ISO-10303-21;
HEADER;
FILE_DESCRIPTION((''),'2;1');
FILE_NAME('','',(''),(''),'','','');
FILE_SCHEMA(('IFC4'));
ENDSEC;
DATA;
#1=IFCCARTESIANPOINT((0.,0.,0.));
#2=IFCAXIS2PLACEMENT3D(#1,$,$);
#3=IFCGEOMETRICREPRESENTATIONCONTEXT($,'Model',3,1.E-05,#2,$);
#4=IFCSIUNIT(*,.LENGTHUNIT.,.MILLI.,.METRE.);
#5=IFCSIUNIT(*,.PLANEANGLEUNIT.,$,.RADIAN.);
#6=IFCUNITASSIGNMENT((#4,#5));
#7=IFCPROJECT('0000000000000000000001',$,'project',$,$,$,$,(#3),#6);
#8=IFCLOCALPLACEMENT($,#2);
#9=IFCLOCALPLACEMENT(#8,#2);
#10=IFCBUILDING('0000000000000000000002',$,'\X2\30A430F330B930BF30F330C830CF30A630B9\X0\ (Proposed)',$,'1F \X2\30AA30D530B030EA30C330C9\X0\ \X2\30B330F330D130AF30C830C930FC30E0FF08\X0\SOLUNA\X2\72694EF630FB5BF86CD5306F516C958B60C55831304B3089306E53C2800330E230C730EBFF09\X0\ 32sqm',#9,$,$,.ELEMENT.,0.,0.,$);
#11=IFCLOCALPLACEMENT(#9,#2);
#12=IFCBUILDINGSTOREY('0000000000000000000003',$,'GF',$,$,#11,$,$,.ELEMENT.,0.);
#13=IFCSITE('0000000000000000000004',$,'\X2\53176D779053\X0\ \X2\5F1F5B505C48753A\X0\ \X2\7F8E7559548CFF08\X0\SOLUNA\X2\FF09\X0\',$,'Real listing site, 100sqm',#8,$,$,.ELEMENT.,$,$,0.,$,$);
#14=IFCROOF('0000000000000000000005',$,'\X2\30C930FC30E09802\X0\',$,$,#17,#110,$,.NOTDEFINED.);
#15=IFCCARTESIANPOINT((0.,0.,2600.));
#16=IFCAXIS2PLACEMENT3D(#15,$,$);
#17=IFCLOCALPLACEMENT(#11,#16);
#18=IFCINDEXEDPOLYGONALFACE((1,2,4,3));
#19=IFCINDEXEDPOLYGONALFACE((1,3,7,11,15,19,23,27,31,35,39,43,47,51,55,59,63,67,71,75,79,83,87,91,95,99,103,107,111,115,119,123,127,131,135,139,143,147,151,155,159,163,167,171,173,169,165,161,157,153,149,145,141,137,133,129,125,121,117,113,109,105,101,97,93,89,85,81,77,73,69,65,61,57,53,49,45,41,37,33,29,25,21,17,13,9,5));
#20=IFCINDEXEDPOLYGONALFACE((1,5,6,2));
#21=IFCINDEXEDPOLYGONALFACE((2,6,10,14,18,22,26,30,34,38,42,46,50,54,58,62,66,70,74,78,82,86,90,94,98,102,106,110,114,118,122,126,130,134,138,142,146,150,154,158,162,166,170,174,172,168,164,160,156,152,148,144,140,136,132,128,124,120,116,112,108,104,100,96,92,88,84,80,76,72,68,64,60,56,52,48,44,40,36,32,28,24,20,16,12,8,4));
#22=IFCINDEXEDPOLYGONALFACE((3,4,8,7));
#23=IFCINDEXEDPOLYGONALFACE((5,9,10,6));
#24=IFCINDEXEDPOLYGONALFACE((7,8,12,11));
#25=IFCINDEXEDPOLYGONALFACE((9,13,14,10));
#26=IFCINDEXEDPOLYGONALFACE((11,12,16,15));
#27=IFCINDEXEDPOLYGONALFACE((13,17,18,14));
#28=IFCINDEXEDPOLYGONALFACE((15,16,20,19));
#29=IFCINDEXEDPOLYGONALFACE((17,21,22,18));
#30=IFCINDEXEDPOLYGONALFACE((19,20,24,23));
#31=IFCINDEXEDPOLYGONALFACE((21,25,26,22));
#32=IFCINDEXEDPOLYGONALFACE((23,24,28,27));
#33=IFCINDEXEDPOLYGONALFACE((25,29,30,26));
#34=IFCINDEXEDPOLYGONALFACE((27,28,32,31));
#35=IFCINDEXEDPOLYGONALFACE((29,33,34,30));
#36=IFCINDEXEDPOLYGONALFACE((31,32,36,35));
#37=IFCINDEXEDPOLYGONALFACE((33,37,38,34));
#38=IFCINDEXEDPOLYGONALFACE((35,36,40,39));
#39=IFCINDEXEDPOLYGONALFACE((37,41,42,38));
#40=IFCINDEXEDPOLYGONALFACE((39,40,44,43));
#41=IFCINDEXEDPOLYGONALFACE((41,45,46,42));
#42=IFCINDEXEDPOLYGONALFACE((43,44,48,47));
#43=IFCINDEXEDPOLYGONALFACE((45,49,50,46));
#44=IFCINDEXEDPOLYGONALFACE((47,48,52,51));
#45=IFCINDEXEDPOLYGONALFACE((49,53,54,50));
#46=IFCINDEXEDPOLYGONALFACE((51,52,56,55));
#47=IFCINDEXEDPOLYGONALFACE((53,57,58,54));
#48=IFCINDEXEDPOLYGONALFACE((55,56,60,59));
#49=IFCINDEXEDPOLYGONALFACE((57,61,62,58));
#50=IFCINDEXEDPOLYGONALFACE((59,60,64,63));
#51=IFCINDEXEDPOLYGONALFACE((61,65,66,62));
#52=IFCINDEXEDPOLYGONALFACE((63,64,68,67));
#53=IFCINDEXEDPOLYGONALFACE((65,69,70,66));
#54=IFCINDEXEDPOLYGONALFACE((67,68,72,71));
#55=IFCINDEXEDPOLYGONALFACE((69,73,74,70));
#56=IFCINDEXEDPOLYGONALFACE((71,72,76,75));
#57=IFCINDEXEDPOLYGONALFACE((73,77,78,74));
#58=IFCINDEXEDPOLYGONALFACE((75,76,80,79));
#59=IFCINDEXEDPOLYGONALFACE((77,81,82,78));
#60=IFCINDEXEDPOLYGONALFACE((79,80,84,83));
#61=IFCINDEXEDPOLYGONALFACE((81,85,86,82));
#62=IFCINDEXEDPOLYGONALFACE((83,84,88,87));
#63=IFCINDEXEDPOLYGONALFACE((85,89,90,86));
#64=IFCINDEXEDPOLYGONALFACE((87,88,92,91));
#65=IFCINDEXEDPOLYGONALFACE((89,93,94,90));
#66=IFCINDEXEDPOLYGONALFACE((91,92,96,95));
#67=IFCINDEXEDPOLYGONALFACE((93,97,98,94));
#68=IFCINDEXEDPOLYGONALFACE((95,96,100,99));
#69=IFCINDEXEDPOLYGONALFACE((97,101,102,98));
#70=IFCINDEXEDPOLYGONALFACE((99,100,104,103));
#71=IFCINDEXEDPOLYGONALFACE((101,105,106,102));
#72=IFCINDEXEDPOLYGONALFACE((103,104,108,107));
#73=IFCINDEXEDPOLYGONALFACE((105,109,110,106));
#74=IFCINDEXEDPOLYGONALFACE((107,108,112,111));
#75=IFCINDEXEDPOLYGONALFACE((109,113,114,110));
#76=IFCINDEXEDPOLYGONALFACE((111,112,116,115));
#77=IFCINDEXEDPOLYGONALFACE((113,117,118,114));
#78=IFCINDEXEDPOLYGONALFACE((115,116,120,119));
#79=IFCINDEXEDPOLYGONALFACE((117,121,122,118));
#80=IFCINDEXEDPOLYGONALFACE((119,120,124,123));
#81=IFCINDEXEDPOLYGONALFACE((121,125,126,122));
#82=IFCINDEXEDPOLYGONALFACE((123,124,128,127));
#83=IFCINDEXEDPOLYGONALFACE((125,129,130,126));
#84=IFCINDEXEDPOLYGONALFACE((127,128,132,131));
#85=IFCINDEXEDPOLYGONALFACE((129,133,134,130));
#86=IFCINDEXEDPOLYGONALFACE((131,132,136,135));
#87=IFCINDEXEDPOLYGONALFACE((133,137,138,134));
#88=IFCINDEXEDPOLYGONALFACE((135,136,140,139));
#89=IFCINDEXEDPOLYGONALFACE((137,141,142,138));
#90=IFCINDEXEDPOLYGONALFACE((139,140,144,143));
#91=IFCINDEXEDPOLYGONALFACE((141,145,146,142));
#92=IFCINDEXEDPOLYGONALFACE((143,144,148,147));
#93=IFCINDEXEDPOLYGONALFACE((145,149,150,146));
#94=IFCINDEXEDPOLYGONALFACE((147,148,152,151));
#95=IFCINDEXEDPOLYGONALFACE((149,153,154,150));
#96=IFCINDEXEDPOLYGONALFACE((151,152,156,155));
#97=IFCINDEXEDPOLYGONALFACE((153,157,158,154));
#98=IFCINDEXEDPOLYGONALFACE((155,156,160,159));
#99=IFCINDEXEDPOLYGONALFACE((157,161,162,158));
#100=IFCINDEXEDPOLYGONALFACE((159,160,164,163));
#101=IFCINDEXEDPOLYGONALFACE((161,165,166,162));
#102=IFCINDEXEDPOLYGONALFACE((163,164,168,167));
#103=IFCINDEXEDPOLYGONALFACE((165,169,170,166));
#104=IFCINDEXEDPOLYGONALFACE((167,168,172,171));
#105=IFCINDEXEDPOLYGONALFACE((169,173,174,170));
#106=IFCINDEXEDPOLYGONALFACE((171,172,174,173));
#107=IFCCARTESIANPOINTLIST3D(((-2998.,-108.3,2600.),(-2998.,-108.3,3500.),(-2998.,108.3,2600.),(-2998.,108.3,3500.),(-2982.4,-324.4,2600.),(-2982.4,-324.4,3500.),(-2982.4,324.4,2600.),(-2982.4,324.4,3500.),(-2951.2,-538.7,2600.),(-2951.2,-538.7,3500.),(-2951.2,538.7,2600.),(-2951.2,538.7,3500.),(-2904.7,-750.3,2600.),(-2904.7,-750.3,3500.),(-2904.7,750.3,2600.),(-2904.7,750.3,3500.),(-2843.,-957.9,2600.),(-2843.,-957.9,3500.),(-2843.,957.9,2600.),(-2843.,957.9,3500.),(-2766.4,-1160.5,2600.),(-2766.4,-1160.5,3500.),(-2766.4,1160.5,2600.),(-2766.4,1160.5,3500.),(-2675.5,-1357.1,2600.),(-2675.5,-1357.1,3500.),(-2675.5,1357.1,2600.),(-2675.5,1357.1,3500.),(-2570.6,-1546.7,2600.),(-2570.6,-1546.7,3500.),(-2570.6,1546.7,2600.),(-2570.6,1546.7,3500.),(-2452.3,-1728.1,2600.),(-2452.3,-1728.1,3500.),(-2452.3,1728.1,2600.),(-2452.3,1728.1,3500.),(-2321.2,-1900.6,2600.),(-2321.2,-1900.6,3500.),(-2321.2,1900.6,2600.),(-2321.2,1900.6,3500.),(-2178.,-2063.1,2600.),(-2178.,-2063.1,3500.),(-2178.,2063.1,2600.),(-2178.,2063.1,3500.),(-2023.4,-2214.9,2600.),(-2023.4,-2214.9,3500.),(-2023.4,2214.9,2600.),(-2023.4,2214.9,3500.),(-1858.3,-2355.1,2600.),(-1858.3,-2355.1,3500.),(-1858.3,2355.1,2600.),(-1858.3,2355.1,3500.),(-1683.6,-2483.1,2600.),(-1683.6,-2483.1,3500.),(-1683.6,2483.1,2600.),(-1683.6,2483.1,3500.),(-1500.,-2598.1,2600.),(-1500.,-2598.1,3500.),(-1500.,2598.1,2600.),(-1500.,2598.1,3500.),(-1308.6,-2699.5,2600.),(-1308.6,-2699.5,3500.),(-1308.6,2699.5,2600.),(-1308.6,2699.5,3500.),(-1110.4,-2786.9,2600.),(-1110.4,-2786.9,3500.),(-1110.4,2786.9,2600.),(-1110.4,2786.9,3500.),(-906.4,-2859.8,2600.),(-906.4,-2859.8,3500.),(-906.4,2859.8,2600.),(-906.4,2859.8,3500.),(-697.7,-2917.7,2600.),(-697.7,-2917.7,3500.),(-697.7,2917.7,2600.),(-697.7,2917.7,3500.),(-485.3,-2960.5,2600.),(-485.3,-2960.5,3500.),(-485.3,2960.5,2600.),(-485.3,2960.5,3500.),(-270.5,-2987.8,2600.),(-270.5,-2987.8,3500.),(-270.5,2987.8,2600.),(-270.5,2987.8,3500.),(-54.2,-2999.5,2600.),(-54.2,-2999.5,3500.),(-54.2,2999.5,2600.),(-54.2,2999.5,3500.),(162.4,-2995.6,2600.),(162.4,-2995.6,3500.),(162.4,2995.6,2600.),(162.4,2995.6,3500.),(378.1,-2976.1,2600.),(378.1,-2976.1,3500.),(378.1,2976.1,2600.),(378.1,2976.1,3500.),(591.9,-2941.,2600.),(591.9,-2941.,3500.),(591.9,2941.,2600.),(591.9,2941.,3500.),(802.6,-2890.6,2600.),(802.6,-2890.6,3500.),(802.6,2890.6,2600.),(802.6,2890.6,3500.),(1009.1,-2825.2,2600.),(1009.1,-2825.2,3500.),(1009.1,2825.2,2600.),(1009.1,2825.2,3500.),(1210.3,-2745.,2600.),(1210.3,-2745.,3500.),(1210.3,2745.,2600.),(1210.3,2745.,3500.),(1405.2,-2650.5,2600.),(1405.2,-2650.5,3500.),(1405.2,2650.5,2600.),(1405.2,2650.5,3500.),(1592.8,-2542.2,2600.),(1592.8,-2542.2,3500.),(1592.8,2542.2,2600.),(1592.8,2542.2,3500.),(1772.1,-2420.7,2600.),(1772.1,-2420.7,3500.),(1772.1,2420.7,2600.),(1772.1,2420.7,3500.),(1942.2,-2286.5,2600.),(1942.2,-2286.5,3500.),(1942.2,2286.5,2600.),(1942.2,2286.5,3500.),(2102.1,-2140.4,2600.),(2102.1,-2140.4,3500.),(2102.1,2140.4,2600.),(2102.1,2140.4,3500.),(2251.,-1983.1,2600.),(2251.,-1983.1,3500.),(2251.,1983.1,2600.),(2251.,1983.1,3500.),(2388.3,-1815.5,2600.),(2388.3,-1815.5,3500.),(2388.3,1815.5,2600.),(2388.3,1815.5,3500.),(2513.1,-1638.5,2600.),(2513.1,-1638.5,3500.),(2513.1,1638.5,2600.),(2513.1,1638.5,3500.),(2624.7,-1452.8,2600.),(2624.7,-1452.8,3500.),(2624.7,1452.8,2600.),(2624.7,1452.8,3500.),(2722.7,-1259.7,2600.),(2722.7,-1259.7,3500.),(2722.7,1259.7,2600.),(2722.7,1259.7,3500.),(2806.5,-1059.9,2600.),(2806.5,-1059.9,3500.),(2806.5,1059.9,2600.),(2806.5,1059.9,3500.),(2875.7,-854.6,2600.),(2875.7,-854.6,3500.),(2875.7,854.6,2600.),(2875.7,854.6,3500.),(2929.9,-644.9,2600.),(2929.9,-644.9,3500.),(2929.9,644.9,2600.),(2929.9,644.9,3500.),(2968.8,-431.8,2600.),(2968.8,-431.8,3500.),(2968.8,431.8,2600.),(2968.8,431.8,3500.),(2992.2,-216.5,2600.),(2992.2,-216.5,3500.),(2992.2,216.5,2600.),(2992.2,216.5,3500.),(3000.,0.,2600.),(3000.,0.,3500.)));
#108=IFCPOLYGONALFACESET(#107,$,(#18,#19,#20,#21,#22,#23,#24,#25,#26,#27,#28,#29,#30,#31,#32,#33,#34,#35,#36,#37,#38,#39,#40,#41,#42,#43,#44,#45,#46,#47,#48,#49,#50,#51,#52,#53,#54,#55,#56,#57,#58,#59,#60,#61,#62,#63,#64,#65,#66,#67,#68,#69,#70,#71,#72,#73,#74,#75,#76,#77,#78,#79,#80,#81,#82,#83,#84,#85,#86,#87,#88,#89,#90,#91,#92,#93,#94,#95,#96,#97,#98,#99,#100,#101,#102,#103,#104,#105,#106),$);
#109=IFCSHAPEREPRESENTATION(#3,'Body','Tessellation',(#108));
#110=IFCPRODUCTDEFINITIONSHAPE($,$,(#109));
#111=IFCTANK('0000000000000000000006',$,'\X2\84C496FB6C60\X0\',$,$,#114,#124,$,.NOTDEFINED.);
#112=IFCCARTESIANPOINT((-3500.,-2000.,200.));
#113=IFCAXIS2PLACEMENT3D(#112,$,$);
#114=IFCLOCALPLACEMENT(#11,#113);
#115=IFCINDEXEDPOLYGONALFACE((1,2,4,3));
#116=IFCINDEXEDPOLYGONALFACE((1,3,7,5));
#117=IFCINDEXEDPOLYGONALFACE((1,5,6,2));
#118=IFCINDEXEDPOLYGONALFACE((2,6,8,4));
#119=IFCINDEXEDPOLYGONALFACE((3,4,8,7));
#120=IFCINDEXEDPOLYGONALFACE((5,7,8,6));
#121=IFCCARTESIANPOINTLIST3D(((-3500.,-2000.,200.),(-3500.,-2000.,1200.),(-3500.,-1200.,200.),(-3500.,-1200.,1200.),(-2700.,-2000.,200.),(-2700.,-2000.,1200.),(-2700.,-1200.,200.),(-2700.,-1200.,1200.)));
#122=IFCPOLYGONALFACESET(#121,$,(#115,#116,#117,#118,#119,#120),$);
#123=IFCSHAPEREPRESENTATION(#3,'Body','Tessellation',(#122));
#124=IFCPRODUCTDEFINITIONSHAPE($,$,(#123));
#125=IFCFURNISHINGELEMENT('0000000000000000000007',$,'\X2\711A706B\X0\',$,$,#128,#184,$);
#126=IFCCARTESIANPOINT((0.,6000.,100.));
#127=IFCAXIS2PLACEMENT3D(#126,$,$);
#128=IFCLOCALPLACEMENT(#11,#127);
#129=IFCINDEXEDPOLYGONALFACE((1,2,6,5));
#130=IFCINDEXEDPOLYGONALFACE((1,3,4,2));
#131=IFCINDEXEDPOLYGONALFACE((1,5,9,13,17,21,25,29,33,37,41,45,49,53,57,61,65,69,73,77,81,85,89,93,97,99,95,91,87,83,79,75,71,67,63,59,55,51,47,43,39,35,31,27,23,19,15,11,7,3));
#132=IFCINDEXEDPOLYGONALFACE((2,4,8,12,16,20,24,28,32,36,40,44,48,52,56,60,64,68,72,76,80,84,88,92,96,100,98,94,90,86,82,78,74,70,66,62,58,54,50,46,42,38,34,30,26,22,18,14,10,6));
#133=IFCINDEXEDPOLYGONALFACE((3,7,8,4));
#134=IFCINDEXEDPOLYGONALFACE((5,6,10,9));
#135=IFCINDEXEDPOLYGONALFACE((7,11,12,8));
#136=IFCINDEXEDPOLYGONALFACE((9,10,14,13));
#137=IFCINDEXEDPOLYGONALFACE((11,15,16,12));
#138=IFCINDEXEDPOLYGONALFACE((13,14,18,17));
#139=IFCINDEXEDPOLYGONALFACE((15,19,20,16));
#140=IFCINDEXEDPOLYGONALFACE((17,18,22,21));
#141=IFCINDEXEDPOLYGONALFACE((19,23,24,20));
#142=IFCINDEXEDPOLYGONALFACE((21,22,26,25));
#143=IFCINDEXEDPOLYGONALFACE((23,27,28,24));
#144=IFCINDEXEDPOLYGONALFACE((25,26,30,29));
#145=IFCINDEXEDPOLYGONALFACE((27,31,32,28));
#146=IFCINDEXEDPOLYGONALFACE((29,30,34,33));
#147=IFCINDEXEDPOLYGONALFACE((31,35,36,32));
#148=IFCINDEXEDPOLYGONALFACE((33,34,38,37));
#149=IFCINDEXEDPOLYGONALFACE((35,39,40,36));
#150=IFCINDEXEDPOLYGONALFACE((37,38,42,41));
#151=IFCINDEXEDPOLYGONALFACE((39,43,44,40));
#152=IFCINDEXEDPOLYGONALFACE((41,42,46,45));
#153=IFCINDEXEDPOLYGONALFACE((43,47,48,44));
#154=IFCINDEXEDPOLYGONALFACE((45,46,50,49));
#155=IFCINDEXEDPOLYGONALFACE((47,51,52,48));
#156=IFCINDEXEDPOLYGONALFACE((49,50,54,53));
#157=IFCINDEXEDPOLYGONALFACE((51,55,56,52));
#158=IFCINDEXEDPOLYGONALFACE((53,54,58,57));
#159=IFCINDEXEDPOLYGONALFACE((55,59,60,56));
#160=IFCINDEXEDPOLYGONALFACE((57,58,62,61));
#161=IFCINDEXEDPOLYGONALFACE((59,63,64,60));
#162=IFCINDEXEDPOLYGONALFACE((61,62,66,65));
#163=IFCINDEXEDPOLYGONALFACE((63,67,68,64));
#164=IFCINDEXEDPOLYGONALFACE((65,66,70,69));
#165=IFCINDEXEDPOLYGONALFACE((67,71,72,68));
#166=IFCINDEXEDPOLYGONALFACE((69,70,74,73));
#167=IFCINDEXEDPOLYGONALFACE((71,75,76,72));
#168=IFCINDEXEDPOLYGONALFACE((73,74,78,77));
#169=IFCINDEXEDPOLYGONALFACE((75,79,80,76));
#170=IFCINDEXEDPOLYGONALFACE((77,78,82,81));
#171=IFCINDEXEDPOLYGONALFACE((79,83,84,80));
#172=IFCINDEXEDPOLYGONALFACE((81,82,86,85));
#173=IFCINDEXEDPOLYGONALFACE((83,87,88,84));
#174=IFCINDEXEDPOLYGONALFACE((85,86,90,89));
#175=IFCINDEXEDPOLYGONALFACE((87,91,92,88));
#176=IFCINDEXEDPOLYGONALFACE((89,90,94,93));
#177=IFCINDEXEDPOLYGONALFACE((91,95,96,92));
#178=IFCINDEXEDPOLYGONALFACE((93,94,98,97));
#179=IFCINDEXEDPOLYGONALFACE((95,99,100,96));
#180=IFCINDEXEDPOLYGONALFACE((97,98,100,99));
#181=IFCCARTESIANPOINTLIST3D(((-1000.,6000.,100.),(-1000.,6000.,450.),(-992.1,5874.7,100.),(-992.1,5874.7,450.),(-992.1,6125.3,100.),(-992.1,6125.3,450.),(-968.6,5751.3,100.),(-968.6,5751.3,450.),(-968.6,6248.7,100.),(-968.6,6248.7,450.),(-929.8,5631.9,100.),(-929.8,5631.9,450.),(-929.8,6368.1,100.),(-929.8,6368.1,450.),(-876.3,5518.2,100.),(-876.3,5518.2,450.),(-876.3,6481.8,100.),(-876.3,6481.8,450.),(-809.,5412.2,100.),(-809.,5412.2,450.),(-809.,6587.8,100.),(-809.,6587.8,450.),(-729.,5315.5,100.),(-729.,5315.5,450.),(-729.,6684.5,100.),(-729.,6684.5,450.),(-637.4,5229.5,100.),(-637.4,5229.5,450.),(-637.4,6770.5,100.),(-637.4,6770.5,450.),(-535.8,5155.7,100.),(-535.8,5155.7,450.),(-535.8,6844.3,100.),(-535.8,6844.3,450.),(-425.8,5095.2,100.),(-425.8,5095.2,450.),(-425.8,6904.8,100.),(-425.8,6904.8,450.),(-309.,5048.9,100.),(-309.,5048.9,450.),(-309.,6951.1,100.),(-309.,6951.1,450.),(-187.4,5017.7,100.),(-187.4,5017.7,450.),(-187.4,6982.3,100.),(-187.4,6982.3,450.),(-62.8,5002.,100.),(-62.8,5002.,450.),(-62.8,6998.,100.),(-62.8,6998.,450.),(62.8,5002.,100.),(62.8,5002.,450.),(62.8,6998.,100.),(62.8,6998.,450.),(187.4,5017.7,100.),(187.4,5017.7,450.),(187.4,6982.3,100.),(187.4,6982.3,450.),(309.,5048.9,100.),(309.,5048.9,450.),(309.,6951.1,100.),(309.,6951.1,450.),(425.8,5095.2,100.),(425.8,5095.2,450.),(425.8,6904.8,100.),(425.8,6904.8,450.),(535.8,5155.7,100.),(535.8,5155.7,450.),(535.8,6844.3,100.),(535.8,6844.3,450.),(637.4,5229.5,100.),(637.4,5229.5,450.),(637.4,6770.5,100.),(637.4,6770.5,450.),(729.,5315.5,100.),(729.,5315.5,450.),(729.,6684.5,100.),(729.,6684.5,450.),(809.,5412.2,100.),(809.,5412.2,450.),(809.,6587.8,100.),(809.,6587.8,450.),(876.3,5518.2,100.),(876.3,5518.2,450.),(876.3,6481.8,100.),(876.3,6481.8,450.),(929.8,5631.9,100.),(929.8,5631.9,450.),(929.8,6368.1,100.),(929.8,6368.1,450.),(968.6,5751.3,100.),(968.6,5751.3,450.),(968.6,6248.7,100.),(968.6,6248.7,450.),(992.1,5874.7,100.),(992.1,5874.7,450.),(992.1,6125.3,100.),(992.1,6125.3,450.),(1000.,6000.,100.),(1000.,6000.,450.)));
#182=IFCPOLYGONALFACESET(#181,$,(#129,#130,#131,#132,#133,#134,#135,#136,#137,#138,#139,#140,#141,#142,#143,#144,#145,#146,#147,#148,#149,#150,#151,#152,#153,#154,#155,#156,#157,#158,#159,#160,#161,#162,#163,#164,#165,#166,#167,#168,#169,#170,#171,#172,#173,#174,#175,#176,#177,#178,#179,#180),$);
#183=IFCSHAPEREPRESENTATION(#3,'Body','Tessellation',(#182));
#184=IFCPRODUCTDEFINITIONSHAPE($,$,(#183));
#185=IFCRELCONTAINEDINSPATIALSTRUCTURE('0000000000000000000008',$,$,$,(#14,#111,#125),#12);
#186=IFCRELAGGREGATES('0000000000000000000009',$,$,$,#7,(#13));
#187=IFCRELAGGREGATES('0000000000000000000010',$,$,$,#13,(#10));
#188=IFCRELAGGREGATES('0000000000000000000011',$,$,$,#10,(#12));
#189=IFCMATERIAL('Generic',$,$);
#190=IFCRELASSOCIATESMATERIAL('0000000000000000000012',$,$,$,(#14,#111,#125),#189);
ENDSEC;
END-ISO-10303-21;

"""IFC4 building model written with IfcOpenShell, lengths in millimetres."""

from ifc_helpers import new_model, si_unit, frame, frame_2d, origin, origin_2d, place, context, project, spatial, rectangle, circle, extrude, material, element, save


model = new_model("IFC4")

# Units and contexts
model_context = context("Model", 3, precision=1e-05, world=origin())
ifc_project = project(units=[si_unit("LENGTHUNIT", "METRE", prefix="MILLI"), si_unit("PLANEANGLEUNIT", "RADIAN")], contexts=[model_context])

# Site, building, storey
site_placement = place(None, origin())
site = spatial("IfcSite", under=ifc_project, at=site_placement, Name="北海道 弟子屈町 美留和（SOLUNA）", ObjectType="Real listing site, 100sqm", CompositionType="ELEMENT", RefElevation=0.0)
building_placement = place(site_placement, origin())
building = spatial("IfcBuilding", under=site, at=building_placement, Name="インスタントハウス (Proposed)", ObjectType="1F オフグリッド コンパクトドーム（SOLUNA物件・寸法は公開情報からの参考モデル） 32sqm", CompositionType="ELEMENT", ElevationOfRefHeight=0.0, ElevationOfTerrain=0.0)
storey_placement = place(building_placement, origin())
storey = spatial("IfcBuildingStorey", under=building, at=storey_placement, Name="GF", CompositionType="ELEMENT", Elevation=0.0)

# Shared definitions
ifc_material_1 = material(Name="Generic")

# Roof
roof_1_placement = place(storey_placement, frame((0.0, 0.0, 2600.0)))
element("IfcRoof", 1, at=roof_1_placement, inside=storey, material=ifc_material_1, Name="ドーム頂", PredefinedType="NOTDEFINED", context=model_context, shape_type="SweptSolid", body=[
    extrude(circle(Radius=3000.0, at=origin_2d()), frame((0.0, 0.0, 2600.0)), (0.0, 0.0, 1.0), 900.0),
])

# Tank
tank_placement = place(storey_placement, frame((-3500.0, -2000.0, 200.0)))
element("IfcTank", 2, at=tank_placement, inside=storey, material=ifc_material_1, Name="蓄電池", PredefinedType="NOTDEFINED", context=model_context, shape_type="SweptSolid", body=[
    extrude(rectangle(XDim=800.0, YDim=800.0, at=frame_2d((400.0, 400.0))), frame((-3500.0, -2000.0, 200.0)), (0.0, 0.0, 1.0), 1000.0),
])

# Furnishing element
furnishing_1_placement = place(storey_placement, frame((0.0, 6000.0, 100.0)))
element("IfcFurnishingElement", 3, at=furnishing_1_placement, inside=storey, material=ifc_material_1, Name="焚火", context=model_context, shape_type="SweptSolid", body=[
    extrude(circle(Radius=1000.0, at=origin_2d()), frame((0.0, 6000.0, 100.0)), (0.0, 0.0, 1.0), 350.0),
])

save(model, "model.ifc")
